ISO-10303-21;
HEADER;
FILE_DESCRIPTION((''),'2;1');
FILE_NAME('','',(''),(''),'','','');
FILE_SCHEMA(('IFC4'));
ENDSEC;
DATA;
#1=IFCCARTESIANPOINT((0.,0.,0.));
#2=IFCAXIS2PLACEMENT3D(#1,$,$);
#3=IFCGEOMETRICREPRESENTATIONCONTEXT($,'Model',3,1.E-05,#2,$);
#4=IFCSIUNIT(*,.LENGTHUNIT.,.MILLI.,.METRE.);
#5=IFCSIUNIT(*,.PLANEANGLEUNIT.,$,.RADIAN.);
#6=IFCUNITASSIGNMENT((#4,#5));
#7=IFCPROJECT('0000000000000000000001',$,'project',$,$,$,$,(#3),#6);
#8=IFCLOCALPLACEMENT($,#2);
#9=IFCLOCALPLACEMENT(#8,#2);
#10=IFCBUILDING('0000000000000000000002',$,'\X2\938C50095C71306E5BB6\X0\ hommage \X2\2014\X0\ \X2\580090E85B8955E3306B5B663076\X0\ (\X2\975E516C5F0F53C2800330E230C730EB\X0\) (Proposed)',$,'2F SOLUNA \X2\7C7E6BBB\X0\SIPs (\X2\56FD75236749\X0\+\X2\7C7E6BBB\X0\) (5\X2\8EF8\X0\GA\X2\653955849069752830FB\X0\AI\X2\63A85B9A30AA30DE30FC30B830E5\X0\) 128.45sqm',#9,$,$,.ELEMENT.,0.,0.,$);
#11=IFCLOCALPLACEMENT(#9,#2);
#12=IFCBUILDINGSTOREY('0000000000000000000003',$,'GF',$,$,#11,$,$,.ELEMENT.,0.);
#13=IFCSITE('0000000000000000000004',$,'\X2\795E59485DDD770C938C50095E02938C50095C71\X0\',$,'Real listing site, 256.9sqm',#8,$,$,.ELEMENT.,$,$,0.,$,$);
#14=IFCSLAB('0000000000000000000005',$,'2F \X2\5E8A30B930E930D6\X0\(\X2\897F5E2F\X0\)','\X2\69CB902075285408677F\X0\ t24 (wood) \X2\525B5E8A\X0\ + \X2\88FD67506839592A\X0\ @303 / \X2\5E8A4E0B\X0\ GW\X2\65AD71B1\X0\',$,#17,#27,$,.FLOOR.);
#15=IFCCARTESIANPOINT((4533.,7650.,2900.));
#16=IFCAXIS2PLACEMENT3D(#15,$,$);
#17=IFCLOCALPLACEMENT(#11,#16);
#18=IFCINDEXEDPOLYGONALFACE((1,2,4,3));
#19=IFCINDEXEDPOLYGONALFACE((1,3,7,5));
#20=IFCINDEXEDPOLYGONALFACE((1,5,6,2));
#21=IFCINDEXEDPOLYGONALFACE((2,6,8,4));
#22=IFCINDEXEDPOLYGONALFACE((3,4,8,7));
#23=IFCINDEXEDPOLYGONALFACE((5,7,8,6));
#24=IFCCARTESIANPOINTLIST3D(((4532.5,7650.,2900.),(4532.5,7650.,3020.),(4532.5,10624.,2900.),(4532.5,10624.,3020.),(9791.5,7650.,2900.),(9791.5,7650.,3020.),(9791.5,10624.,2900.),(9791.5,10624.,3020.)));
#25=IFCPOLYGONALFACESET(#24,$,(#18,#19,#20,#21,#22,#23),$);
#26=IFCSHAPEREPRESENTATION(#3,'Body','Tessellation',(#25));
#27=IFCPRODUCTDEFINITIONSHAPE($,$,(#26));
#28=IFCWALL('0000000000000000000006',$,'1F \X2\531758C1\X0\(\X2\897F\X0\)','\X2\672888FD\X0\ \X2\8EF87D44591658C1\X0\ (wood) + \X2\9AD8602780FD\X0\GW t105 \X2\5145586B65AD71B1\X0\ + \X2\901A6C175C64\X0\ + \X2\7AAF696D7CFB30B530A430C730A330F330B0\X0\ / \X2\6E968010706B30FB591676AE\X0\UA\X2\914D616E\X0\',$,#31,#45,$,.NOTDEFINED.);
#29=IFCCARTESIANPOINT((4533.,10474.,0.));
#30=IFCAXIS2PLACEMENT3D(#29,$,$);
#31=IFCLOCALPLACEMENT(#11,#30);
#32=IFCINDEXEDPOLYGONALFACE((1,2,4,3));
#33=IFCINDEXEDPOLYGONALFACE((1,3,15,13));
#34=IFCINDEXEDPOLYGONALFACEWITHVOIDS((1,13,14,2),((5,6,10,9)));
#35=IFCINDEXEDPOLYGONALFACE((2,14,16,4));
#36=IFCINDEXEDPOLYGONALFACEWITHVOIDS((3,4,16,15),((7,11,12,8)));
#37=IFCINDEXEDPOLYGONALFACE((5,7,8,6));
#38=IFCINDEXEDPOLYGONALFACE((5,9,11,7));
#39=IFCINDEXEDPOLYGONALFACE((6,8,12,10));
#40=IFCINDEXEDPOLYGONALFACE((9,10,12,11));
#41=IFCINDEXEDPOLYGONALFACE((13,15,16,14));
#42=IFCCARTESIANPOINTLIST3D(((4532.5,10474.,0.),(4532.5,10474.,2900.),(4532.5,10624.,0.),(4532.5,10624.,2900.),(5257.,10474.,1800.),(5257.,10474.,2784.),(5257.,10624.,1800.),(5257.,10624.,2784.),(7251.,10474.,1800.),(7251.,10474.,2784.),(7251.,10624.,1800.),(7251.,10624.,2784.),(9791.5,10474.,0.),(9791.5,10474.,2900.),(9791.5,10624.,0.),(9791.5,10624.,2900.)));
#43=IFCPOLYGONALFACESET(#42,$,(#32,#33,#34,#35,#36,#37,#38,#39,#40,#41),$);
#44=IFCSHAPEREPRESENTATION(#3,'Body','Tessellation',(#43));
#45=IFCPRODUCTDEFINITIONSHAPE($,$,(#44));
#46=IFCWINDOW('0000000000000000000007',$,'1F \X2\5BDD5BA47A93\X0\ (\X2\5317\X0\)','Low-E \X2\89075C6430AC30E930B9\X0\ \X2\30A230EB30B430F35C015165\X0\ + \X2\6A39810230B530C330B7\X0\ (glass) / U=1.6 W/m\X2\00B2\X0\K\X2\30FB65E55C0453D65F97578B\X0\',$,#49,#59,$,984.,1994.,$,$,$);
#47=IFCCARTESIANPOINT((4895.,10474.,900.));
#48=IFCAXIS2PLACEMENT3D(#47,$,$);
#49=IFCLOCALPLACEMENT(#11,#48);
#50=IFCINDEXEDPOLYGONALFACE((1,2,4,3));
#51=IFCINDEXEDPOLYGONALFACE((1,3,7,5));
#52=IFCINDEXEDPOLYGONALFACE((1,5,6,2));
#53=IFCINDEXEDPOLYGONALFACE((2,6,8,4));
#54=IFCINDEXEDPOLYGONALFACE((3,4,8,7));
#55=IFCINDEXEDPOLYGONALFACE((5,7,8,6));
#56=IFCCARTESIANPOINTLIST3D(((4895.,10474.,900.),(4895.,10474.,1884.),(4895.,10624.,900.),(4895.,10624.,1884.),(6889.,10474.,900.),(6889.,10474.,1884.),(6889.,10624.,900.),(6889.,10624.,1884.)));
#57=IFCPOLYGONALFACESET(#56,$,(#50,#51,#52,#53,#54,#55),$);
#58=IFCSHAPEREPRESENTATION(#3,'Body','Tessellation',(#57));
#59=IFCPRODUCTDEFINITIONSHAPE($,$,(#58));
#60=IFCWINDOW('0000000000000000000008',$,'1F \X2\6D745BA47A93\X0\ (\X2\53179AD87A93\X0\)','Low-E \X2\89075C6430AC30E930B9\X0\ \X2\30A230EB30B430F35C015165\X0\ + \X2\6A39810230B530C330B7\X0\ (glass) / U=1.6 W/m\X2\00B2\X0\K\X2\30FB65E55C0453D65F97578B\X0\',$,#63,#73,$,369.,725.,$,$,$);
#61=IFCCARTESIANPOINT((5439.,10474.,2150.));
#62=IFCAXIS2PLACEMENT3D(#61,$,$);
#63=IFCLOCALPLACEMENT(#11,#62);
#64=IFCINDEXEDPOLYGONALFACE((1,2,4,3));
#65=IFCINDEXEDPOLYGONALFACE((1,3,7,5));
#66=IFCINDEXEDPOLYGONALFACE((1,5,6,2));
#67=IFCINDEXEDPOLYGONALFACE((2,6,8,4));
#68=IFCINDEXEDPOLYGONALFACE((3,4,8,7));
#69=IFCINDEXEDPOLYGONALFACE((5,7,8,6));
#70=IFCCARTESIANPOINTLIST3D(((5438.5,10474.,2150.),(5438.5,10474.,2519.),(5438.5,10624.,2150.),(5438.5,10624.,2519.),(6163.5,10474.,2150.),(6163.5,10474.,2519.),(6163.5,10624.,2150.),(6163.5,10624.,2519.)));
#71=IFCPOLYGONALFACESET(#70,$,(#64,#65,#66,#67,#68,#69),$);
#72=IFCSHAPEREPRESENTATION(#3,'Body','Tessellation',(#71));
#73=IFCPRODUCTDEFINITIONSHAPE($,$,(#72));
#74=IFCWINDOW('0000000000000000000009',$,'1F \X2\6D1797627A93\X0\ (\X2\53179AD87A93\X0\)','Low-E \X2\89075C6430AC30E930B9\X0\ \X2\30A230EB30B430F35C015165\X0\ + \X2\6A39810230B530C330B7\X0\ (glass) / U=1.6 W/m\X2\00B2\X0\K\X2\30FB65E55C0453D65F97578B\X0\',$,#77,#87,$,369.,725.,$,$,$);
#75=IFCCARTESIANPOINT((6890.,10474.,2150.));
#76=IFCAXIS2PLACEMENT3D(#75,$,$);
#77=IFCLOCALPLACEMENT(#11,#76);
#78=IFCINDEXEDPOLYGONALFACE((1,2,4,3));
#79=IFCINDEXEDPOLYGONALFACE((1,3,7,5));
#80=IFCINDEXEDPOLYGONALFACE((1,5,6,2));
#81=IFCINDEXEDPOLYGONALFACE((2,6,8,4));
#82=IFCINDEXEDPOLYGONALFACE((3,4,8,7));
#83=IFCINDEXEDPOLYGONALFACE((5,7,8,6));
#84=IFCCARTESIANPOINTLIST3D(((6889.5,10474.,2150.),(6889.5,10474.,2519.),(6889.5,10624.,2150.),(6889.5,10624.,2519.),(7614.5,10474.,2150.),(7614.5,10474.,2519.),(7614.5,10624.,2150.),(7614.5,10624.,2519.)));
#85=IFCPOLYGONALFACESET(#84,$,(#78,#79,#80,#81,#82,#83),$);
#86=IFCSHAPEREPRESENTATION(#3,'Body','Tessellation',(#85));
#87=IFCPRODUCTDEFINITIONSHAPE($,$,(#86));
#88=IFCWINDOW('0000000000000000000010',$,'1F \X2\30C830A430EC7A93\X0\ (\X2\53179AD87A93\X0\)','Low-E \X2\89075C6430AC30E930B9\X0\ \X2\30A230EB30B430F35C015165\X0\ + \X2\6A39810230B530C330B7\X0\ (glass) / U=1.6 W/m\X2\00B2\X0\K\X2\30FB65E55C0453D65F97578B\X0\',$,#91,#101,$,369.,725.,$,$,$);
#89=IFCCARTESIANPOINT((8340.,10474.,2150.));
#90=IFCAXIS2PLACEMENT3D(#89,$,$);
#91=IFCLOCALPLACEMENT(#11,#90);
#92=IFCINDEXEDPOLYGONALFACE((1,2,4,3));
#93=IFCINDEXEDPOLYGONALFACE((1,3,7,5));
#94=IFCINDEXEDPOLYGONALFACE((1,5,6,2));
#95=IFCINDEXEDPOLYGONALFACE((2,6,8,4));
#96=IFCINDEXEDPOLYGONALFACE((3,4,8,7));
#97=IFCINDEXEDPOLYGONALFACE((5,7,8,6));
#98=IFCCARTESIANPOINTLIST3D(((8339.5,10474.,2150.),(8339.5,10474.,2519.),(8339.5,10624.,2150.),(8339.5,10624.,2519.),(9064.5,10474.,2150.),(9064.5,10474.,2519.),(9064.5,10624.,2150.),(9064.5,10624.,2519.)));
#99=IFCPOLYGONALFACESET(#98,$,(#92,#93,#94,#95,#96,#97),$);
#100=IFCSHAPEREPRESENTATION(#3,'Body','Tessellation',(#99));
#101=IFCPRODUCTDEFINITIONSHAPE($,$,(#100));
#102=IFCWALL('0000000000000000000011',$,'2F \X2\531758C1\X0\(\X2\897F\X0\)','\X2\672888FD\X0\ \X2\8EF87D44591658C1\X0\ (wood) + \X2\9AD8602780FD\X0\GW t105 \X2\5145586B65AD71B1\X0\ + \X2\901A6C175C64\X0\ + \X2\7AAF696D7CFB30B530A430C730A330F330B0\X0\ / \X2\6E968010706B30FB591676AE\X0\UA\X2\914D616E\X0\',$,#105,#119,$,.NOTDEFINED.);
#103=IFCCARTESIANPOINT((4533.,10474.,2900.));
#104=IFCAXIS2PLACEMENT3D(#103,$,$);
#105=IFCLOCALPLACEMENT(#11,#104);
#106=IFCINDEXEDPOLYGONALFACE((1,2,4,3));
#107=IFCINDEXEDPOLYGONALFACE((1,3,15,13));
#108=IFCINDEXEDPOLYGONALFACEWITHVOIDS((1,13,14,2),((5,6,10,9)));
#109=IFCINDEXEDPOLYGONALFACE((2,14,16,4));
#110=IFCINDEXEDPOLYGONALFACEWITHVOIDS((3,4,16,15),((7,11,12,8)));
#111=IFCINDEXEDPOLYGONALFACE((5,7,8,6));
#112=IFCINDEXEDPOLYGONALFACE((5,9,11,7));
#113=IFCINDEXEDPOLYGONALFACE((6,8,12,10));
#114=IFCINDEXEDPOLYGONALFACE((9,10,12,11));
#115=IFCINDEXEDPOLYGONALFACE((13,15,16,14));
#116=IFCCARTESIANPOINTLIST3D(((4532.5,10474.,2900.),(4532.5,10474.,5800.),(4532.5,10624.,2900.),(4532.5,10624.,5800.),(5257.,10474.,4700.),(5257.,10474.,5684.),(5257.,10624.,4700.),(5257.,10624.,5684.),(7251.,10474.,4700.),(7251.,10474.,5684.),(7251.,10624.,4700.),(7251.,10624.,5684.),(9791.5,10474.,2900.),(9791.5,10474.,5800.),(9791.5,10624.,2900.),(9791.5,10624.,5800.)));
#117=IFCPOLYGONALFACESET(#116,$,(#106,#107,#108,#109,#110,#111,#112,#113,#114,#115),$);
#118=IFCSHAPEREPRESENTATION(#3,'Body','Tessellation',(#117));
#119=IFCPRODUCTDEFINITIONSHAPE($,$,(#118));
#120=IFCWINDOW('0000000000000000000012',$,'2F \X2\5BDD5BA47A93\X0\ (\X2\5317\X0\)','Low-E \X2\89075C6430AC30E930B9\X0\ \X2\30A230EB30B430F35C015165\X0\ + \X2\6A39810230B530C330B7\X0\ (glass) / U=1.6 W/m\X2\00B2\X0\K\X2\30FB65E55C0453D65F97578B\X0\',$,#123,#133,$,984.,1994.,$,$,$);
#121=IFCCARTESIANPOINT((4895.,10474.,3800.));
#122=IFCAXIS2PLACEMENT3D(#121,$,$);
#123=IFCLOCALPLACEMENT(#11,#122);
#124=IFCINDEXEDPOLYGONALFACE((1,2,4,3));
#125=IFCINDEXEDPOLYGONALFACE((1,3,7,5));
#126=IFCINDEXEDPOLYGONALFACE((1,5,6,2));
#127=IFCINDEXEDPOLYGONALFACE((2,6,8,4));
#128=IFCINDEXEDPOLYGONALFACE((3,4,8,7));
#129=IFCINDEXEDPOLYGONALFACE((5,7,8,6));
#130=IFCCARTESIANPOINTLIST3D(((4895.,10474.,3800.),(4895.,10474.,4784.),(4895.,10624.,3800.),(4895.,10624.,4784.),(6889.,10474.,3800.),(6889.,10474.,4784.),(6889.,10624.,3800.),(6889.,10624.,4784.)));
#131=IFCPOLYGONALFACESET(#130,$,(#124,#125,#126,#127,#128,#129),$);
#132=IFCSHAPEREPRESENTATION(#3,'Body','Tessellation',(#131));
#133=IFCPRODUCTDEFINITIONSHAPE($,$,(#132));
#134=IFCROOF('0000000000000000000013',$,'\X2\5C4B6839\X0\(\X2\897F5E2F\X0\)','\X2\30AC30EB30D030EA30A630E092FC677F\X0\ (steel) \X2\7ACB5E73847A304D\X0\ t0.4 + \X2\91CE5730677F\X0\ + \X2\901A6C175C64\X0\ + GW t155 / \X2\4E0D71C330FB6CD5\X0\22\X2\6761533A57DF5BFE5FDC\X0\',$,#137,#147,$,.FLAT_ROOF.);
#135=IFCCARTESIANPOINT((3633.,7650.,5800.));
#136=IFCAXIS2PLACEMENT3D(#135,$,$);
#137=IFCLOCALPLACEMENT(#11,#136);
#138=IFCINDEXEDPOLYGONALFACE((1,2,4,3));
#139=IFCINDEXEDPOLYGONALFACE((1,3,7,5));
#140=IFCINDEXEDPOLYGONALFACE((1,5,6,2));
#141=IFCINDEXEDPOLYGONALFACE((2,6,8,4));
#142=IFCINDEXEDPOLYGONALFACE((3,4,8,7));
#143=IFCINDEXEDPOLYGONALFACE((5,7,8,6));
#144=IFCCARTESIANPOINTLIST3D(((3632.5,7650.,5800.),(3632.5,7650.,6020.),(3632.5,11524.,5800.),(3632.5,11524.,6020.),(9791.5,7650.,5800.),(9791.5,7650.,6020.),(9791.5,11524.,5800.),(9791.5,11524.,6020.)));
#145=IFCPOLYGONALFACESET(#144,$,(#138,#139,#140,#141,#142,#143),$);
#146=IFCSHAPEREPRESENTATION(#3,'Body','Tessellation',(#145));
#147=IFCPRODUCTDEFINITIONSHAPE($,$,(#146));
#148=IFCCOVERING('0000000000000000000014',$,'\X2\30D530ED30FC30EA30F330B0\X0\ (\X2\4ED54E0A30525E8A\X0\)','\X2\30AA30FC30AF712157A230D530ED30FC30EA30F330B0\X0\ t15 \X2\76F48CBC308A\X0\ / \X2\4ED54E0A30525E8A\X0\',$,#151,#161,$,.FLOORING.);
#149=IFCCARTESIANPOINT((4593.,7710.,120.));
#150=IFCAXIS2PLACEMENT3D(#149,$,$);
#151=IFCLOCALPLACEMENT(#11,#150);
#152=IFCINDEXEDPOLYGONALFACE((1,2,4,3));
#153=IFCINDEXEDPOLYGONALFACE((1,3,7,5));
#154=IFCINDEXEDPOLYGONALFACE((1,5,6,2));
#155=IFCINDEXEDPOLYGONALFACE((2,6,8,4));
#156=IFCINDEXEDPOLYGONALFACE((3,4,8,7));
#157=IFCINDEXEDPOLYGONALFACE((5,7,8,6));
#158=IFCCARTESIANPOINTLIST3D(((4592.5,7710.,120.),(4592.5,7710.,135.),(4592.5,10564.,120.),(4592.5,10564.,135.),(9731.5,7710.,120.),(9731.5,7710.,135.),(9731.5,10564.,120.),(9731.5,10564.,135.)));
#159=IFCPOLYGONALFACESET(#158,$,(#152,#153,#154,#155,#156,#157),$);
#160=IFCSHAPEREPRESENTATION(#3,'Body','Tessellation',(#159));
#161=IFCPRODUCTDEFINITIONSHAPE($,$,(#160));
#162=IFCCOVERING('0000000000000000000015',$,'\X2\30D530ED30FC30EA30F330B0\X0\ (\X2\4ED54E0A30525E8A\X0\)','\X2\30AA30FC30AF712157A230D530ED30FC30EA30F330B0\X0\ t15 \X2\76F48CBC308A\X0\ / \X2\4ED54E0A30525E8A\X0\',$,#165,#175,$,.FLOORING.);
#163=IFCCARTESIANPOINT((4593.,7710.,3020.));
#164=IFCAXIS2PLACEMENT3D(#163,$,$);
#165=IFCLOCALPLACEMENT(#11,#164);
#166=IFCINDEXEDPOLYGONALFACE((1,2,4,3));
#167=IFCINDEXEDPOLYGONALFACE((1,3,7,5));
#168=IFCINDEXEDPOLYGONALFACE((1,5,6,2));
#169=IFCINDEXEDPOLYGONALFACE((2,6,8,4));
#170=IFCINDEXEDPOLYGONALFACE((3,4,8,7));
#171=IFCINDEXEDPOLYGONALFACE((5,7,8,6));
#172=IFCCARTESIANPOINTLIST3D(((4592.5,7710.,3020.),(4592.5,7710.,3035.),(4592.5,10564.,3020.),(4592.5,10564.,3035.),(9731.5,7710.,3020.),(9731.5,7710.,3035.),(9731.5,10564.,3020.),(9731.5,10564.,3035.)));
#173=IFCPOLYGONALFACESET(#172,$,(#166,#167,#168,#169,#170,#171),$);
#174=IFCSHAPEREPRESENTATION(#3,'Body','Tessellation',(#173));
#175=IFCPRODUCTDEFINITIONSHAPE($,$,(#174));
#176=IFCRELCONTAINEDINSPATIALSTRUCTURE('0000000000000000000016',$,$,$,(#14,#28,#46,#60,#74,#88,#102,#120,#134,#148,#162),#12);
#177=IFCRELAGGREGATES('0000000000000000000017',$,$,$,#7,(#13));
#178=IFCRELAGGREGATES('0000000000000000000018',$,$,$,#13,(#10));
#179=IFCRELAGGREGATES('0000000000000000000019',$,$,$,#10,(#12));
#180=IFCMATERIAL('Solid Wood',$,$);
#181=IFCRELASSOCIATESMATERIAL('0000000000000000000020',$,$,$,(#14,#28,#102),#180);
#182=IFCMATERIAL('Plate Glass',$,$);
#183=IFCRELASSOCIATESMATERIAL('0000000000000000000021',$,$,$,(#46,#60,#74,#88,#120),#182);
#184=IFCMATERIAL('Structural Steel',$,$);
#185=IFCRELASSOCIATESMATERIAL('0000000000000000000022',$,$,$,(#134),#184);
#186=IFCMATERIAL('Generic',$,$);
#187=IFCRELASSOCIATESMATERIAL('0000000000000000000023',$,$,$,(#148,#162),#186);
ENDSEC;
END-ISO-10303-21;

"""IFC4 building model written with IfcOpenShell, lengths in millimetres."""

from ifc_helpers import new_model, si_unit, frame, frame_2d, origin, place, context, project, spatial, rectangle, extrude, material, element, fill, save


model = new_model("IFC4")

# Units and contexts
model_context = context("Model", 3, precision=1e-05, world=origin())
ifc_project = project(units=[si_unit("LENGTHUNIT", "METRE", prefix="MILLI"), si_unit("PLANEANGLEUNIT", "RADIAN")], contexts=[model_context])

# Site, building, storey
site_placement = place(None, origin())
site = spatial("IfcSite", under=ifc_project, at=site_placement, Name="神奈川県鎌倉市鎌倉山", ObjectType="Real listing site, 256.9sqm", CompositionType="ELEMENT", RefElevation=0.0)
building_placement = place(site_placement, origin())
building = spatial("IfcBuilding", under=site, at=building_placement, Name="鎌倉山の家 hommage — 堀部安嗣に学ぶ (非公式参考モデル) (Proposed)", ObjectType="2F SOLUNA 籾殻SIPs (国産杉+籾殻) (5軸GA改善適用・AI推定オマージュ) 128.45sqm", CompositionType="ELEMENT", ElevationOfRefHeight=0.0, ElevationOfTerrain=0.0)
storey_placement = place(building_placement, origin())
storey = spatial("IfcBuildingStorey", under=building, at=storey_placement, Name="GF", CompositionType="ELEMENT", Elevation=0.0)

# Slab
ifc_material_1 = material(Name="Solid Wood")
slab_1_placement = place(storey_placement, frame((4533.0, 7650.0, 2900.0)))
element("IfcSlab", 1, at=slab_1_placement, inside=storey, material=ifc_material_1, Name="2F 床スラブ(西帯)", Description="構造用合板 t24 (wood) 剛床 + 製材根太 @303 / 床下 GW断熱", PredefinedType="FLOOR", context=model_context, shape_type="SweptSolid", body=[
    extrude(rectangle(XDim=5259.0, YDim=2974.0, at=frame_2d((2629.0, 1487.0))), frame((4533.0, 7650.0, 2900.0)), (0.0, 0.0, 1.0), 120.0),
])

# Wall, openings, windows
wall_1_placement = place(storey_placement, frame((4533.0, 10474.0, 0.0)))
wall_1 = element("IfcWall", 2, at=wall_1_placement, inside=storey, material=ifc_material_1, Name="1F 北壁(西)", Description="木製 軸組外壁 (wood) + 高性能GW t105 充填断熱 + 通気層 + 窯業系サイディング / 準耐火・外皮UA配慮", PredefinedType="NOTDEFINED", context=model_context, shape_type="SweptSolid", body=[
    extrude(rectangle(XDim=5259.0, YDim=150.0, at=frame_2d((2629.0, 75.0))), frame((4533.0, 10474.0, 0.0)), (0.0, 0.0, 1.0), 2900.0),
])
opening_1_placement = place(storey_placement, frame((4895.0, 10474.0, 900.0)))
opening_1 = element("IfcOpeningElement", 3, at=opening_1_placement, cuts=wall_1, PredefinedType="NOTDEFINED", context=model_context, shape_type="SweptSolid", body=[
    extrude(rectangle(XDim=1994.0, YDim=150.0, at=frame_2d((997.0, 75.0))), frame((4895.0, 10474.0, 900.0)), (0.0, 0.0, 1.0), 984.0),
])
opening_2_placement = place(storey_placement, frame((5439.0, 10474.0, 2150.0)))
opening_2 = element("IfcOpeningElement", 4, at=opening_2_placement, cuts=wall_1, PredefinedType="NOTDEFINED", context=model_context, shape_type="SweptSolid", body=[
    extrude(rectangle(XDim=725.0, YDim=150.0, at=frame_2d((362.0, 75.0))), frame((5439.0, 10474.0, 2150.0)), (0.0, 0.0, 1.0), 369.0),
])
opening_3_placement = place(storey_placement, frame((6890.0, 10474.0, 2150.0)))
opening_3 = element("IfcOpeningElement", 5, at=opening_3_placement, cuts=wall_1, PredefinedType="NOTDEFINED", context=model_context, shape_type="SweptSolid", body=[
    extrude(rectangle(XDim=725.0, YDim=150.0, at=frame_2d((362.0, 75.0))), frame((6890.0, 10474.0, 2150.0)), (0.0, 0.0, 1.0), 369.0),
])
opening_4_placement = place(storey_placement, frame((8340.0, 10474.0, 2150.0)))
opening_4 = element("IfcOpeningElement", 6, at=opening_4_placement, cuts=wall_1, PredefinedType="NOTDEFINED", context=model_context, shape_type="SweptSolid", body=[
    extrude(rectangle(XDim=725.0, YDim=150.0, at=frame_2d((362.0, 75.0))), frame((8340.0, 10474.0, 2150.0)), (0.0, 0.0, 1.0), 369.0),
])
ifc_material_2 = material(Name="Plate Glass")
window_1_placement = place(storey_placement, frame((4895.0, 10474.0, 900.0)))
window_1 = element("IfcWindow", 7, at=window_1_placement, inside=storey, material=ifc_material_2, Name="1F 寝室窓 (北)", Description="Low-E 複層ガラス アルゴン封入 + 樹脂サッシ (glass) / U=1.6 W/m²K・日射取得型", OverallHeight=984.0, OverallWidth=1994.0, context=model_context, shape_type="SweptSolid", body=[
    extrude(rectangle(XDim=1994.0, YDim=150.0, at=frame_2d((997.0, 75.0))), frame((4895.0, 10474.0, 900.0)), (0.0, 0.0, 1.0), 984.0),
])
fill(opening_1, window_1)
window_2_placement = place(storey_placement, frame((5439.0, 10474.0, 2150.0)))
window_2 = element("IfcWindow", 8, at=window_2_placement, inside=storey, material=ifc_material_2, Name="1F 浴室窓 (北高窓)", Description="Low-E 複層ガラス アルゴン封入 + 樹脂サッシ (glass) / U=1.6 W/m²K・日射取得型", OverallHeight=369.0, OverallWidth=725.0, context=model_context, shape_type="SweptSolid", body=[
    extrude(rectangle(XDim=725.0, YDim=150.0, at=frame_2d((362.0, 75.0))), frame((5439.0, 10474.0, 2150.0)), (0.0, 0.0, 1.0), 369.0),
])
fill(opening_2, window_2)
window_3_placement = place(storey_placement, frame((6890.0, 10474.0, 2150.0)))
window_3 = element("IfcWindow", 9, at=window_3_placement, inside=storey, material=ifc_material_2, Name="1F 洗面窓 (北高窓)", Description="Low-E 複層ガラス アルゴン封入 + 樹脂サッシ (glass) / U=1.6 W/m²K・日射取得型", OverallHeight=369.0, OverallWidth=725.0, context=model_context, shape_type="SweptSolid", body=[
    extrude(rectangle(XDim=725.0, YDim=150.0, at=frame_2d((362.0, 75.0))), frame((6890.0, 10474.0, 2150.0)), (0.0, 0.0, 1.0), 369.0),
])
fill(opening_3, window_3)
window_4_placement = place(storey_placement, frame((8340.0, 10474.0, 2150.0)))
window_4 = element("IfcWindow", 10, at=window_4_placement, inside=storey, material=ifc_material_2, Name="1F トイレ窓 (北高窓)", Description="Low-E 複層ガラス アルゴン封入 + 樹脂サッシ (glass) / U=1.6 W/m²K・日射取得型", OverallHeight=369.0, OverallWidth=725.0, context=model_context, shape_type="SweptSolid", body=[
    extrude(rectangle(XDim=725.0, YDim=150.0, at=frame_2d((362.0, 75.0))), frame((8340.0, 10474.0, 2150.0)), (0.0, 0.0, 1.0), 369.0),
])
fill(opening_4, window_4)

# Wall, opening, window
wall_2_placement = place(storey_placement, frame((4533.0, 10474.0, 2900.0)))
wall_2 = element("IfcWall", 11, at=wall_2_placement, inside=storey, material=ifc_material_1, Name="2F 北壁(西)", Description="木製 軸組外壁 (wood) + 高性能GW t105 充填断熱 + 通気層 + 窯業系サイディング / 準耐火・外皮UA配慮", PredefinedType="NOTDEFINED", context=model_context, shape_type="SweptSolid", body=[
    extrude(rectangle(XDim=5259.0, YDim=150.0, at=frame_2d((2629.0, 75.0))), frame((4533.0, 10474.0, 2900.0)), (0.0, 0.0, 1.0), 2900.0),
])
opening_5_placement = place(storey_placement, frame((4895.0, 10474.0, 3800.0)))
opening_5 = element("IfcOpeningElement", 12, at=opening_5_placement, cuts=wall_2, PredefinedType="NOTDEFINED", context=model_context, shape_type="SweptSolid", body=[
    extrude(rectangle(XDim=1994.0, YDim=150.0, at=frame_2d((997.0, 75.0))), frame((4895.0, 10474.0, 3800.0)), (0.0, 0.0, 1.0), 984.0),
])
window_5_placement = place(storey_placement, frame((4895.0, 10474.0, 3800.0)))
window_5 = element("IfcWindow", 13, at=window_5_placement, inside=storey, material=ifc_material_2, Name="2F 寝室窓 (北)", Description="Low-E 複層ガラス アルゴン封入 + 樹脂サッシ (glass) / U=1.6 W/m²K・日射取得型", OverallHeight=984.0, OverallWidth=1994.0, context=model_context, shape_type="SweptSolid", body=[
    extrude(rectangle(XDim=1994.0, YDim=150.0, at=frame_2d((997.0, 75.0))), frame((4895.0, 10474.0, 3800.0)), (0.0, 0.0, 1.0), 984.0),
])
fill(opening_5, window_5)

# Roof
ifc_material_3 = material(Name="Structural Steel")
for number, where, name in (
    (14, (3633.0, 7650.0, 5800.0), "屋根(西帯)"),
):
    element("IfcRoof", number, at=place(storey_placement, frame(where)), inside=storey, material=ifc_material_3, Name=name, Description="ガルバリウム鋼板 (steel) 立平葺き t0.4 + 野地板 + 通気層 + GW t155 / 不燃・法22条区域対応", PredefinedType="FLAT_ROOF", context=model_context, shape_type="SweptSolid", body=[
        extrude(rectangle(XDim=6159.0, YDim=3874.0, at=frame_2d((3079.0, 1937.0))), frame((3633.0, 7650.0, 5800.0)), (0.0, 0.0, 1.0), 220.0),
    ])

# Coverings
ifc_material_4 = material(Name="Generic")
covering_1_placement = place(storey_placement, frame((4593.0, 7710.0, 120.0)))
element("IfcCovering", 15, at=covering_1_placement, inside=storey, material=ifc_material_4, Name="フローリング (仕上げ床)", Description="オーク無垢フローリング t15 直貼り / 仕上げ床", PredefinedType="FLOORING", context=model_context, shape_type="SweptSolid", body=[
    extrude(rectangle(XDim=5139.0, YDim=2854.0, at=frame_2d((2569.0, 1427.0))), frame((4593.0, 7710.0, 120.0)), (0.0, 0.0, 1.0), 15.0),
])
covering_2_placement = place(storey_placement, frame((4593.0, 7710.0, 3020.0)))
element("IfcCovering", 16, at=covering_2_placement, inside=storey, material=ifc_material_4, Name="フローリング (仕上げ床)", Description="オーク無垢フローリング t15 直貼り / 仕上げ床", PredefinedType="FLOORING", context=model_context, shape_type="SweptSolid", body=[
    extrude(rectangle(XDim=5139.0, YDim=2854.0, at=frame_2d((2569.0, 1427.0))), frame((4593.0, 7710.0, 3020.0)), (0.0, 0.0, 1.0), 15.0),
])

save(model, "model.ifc")
